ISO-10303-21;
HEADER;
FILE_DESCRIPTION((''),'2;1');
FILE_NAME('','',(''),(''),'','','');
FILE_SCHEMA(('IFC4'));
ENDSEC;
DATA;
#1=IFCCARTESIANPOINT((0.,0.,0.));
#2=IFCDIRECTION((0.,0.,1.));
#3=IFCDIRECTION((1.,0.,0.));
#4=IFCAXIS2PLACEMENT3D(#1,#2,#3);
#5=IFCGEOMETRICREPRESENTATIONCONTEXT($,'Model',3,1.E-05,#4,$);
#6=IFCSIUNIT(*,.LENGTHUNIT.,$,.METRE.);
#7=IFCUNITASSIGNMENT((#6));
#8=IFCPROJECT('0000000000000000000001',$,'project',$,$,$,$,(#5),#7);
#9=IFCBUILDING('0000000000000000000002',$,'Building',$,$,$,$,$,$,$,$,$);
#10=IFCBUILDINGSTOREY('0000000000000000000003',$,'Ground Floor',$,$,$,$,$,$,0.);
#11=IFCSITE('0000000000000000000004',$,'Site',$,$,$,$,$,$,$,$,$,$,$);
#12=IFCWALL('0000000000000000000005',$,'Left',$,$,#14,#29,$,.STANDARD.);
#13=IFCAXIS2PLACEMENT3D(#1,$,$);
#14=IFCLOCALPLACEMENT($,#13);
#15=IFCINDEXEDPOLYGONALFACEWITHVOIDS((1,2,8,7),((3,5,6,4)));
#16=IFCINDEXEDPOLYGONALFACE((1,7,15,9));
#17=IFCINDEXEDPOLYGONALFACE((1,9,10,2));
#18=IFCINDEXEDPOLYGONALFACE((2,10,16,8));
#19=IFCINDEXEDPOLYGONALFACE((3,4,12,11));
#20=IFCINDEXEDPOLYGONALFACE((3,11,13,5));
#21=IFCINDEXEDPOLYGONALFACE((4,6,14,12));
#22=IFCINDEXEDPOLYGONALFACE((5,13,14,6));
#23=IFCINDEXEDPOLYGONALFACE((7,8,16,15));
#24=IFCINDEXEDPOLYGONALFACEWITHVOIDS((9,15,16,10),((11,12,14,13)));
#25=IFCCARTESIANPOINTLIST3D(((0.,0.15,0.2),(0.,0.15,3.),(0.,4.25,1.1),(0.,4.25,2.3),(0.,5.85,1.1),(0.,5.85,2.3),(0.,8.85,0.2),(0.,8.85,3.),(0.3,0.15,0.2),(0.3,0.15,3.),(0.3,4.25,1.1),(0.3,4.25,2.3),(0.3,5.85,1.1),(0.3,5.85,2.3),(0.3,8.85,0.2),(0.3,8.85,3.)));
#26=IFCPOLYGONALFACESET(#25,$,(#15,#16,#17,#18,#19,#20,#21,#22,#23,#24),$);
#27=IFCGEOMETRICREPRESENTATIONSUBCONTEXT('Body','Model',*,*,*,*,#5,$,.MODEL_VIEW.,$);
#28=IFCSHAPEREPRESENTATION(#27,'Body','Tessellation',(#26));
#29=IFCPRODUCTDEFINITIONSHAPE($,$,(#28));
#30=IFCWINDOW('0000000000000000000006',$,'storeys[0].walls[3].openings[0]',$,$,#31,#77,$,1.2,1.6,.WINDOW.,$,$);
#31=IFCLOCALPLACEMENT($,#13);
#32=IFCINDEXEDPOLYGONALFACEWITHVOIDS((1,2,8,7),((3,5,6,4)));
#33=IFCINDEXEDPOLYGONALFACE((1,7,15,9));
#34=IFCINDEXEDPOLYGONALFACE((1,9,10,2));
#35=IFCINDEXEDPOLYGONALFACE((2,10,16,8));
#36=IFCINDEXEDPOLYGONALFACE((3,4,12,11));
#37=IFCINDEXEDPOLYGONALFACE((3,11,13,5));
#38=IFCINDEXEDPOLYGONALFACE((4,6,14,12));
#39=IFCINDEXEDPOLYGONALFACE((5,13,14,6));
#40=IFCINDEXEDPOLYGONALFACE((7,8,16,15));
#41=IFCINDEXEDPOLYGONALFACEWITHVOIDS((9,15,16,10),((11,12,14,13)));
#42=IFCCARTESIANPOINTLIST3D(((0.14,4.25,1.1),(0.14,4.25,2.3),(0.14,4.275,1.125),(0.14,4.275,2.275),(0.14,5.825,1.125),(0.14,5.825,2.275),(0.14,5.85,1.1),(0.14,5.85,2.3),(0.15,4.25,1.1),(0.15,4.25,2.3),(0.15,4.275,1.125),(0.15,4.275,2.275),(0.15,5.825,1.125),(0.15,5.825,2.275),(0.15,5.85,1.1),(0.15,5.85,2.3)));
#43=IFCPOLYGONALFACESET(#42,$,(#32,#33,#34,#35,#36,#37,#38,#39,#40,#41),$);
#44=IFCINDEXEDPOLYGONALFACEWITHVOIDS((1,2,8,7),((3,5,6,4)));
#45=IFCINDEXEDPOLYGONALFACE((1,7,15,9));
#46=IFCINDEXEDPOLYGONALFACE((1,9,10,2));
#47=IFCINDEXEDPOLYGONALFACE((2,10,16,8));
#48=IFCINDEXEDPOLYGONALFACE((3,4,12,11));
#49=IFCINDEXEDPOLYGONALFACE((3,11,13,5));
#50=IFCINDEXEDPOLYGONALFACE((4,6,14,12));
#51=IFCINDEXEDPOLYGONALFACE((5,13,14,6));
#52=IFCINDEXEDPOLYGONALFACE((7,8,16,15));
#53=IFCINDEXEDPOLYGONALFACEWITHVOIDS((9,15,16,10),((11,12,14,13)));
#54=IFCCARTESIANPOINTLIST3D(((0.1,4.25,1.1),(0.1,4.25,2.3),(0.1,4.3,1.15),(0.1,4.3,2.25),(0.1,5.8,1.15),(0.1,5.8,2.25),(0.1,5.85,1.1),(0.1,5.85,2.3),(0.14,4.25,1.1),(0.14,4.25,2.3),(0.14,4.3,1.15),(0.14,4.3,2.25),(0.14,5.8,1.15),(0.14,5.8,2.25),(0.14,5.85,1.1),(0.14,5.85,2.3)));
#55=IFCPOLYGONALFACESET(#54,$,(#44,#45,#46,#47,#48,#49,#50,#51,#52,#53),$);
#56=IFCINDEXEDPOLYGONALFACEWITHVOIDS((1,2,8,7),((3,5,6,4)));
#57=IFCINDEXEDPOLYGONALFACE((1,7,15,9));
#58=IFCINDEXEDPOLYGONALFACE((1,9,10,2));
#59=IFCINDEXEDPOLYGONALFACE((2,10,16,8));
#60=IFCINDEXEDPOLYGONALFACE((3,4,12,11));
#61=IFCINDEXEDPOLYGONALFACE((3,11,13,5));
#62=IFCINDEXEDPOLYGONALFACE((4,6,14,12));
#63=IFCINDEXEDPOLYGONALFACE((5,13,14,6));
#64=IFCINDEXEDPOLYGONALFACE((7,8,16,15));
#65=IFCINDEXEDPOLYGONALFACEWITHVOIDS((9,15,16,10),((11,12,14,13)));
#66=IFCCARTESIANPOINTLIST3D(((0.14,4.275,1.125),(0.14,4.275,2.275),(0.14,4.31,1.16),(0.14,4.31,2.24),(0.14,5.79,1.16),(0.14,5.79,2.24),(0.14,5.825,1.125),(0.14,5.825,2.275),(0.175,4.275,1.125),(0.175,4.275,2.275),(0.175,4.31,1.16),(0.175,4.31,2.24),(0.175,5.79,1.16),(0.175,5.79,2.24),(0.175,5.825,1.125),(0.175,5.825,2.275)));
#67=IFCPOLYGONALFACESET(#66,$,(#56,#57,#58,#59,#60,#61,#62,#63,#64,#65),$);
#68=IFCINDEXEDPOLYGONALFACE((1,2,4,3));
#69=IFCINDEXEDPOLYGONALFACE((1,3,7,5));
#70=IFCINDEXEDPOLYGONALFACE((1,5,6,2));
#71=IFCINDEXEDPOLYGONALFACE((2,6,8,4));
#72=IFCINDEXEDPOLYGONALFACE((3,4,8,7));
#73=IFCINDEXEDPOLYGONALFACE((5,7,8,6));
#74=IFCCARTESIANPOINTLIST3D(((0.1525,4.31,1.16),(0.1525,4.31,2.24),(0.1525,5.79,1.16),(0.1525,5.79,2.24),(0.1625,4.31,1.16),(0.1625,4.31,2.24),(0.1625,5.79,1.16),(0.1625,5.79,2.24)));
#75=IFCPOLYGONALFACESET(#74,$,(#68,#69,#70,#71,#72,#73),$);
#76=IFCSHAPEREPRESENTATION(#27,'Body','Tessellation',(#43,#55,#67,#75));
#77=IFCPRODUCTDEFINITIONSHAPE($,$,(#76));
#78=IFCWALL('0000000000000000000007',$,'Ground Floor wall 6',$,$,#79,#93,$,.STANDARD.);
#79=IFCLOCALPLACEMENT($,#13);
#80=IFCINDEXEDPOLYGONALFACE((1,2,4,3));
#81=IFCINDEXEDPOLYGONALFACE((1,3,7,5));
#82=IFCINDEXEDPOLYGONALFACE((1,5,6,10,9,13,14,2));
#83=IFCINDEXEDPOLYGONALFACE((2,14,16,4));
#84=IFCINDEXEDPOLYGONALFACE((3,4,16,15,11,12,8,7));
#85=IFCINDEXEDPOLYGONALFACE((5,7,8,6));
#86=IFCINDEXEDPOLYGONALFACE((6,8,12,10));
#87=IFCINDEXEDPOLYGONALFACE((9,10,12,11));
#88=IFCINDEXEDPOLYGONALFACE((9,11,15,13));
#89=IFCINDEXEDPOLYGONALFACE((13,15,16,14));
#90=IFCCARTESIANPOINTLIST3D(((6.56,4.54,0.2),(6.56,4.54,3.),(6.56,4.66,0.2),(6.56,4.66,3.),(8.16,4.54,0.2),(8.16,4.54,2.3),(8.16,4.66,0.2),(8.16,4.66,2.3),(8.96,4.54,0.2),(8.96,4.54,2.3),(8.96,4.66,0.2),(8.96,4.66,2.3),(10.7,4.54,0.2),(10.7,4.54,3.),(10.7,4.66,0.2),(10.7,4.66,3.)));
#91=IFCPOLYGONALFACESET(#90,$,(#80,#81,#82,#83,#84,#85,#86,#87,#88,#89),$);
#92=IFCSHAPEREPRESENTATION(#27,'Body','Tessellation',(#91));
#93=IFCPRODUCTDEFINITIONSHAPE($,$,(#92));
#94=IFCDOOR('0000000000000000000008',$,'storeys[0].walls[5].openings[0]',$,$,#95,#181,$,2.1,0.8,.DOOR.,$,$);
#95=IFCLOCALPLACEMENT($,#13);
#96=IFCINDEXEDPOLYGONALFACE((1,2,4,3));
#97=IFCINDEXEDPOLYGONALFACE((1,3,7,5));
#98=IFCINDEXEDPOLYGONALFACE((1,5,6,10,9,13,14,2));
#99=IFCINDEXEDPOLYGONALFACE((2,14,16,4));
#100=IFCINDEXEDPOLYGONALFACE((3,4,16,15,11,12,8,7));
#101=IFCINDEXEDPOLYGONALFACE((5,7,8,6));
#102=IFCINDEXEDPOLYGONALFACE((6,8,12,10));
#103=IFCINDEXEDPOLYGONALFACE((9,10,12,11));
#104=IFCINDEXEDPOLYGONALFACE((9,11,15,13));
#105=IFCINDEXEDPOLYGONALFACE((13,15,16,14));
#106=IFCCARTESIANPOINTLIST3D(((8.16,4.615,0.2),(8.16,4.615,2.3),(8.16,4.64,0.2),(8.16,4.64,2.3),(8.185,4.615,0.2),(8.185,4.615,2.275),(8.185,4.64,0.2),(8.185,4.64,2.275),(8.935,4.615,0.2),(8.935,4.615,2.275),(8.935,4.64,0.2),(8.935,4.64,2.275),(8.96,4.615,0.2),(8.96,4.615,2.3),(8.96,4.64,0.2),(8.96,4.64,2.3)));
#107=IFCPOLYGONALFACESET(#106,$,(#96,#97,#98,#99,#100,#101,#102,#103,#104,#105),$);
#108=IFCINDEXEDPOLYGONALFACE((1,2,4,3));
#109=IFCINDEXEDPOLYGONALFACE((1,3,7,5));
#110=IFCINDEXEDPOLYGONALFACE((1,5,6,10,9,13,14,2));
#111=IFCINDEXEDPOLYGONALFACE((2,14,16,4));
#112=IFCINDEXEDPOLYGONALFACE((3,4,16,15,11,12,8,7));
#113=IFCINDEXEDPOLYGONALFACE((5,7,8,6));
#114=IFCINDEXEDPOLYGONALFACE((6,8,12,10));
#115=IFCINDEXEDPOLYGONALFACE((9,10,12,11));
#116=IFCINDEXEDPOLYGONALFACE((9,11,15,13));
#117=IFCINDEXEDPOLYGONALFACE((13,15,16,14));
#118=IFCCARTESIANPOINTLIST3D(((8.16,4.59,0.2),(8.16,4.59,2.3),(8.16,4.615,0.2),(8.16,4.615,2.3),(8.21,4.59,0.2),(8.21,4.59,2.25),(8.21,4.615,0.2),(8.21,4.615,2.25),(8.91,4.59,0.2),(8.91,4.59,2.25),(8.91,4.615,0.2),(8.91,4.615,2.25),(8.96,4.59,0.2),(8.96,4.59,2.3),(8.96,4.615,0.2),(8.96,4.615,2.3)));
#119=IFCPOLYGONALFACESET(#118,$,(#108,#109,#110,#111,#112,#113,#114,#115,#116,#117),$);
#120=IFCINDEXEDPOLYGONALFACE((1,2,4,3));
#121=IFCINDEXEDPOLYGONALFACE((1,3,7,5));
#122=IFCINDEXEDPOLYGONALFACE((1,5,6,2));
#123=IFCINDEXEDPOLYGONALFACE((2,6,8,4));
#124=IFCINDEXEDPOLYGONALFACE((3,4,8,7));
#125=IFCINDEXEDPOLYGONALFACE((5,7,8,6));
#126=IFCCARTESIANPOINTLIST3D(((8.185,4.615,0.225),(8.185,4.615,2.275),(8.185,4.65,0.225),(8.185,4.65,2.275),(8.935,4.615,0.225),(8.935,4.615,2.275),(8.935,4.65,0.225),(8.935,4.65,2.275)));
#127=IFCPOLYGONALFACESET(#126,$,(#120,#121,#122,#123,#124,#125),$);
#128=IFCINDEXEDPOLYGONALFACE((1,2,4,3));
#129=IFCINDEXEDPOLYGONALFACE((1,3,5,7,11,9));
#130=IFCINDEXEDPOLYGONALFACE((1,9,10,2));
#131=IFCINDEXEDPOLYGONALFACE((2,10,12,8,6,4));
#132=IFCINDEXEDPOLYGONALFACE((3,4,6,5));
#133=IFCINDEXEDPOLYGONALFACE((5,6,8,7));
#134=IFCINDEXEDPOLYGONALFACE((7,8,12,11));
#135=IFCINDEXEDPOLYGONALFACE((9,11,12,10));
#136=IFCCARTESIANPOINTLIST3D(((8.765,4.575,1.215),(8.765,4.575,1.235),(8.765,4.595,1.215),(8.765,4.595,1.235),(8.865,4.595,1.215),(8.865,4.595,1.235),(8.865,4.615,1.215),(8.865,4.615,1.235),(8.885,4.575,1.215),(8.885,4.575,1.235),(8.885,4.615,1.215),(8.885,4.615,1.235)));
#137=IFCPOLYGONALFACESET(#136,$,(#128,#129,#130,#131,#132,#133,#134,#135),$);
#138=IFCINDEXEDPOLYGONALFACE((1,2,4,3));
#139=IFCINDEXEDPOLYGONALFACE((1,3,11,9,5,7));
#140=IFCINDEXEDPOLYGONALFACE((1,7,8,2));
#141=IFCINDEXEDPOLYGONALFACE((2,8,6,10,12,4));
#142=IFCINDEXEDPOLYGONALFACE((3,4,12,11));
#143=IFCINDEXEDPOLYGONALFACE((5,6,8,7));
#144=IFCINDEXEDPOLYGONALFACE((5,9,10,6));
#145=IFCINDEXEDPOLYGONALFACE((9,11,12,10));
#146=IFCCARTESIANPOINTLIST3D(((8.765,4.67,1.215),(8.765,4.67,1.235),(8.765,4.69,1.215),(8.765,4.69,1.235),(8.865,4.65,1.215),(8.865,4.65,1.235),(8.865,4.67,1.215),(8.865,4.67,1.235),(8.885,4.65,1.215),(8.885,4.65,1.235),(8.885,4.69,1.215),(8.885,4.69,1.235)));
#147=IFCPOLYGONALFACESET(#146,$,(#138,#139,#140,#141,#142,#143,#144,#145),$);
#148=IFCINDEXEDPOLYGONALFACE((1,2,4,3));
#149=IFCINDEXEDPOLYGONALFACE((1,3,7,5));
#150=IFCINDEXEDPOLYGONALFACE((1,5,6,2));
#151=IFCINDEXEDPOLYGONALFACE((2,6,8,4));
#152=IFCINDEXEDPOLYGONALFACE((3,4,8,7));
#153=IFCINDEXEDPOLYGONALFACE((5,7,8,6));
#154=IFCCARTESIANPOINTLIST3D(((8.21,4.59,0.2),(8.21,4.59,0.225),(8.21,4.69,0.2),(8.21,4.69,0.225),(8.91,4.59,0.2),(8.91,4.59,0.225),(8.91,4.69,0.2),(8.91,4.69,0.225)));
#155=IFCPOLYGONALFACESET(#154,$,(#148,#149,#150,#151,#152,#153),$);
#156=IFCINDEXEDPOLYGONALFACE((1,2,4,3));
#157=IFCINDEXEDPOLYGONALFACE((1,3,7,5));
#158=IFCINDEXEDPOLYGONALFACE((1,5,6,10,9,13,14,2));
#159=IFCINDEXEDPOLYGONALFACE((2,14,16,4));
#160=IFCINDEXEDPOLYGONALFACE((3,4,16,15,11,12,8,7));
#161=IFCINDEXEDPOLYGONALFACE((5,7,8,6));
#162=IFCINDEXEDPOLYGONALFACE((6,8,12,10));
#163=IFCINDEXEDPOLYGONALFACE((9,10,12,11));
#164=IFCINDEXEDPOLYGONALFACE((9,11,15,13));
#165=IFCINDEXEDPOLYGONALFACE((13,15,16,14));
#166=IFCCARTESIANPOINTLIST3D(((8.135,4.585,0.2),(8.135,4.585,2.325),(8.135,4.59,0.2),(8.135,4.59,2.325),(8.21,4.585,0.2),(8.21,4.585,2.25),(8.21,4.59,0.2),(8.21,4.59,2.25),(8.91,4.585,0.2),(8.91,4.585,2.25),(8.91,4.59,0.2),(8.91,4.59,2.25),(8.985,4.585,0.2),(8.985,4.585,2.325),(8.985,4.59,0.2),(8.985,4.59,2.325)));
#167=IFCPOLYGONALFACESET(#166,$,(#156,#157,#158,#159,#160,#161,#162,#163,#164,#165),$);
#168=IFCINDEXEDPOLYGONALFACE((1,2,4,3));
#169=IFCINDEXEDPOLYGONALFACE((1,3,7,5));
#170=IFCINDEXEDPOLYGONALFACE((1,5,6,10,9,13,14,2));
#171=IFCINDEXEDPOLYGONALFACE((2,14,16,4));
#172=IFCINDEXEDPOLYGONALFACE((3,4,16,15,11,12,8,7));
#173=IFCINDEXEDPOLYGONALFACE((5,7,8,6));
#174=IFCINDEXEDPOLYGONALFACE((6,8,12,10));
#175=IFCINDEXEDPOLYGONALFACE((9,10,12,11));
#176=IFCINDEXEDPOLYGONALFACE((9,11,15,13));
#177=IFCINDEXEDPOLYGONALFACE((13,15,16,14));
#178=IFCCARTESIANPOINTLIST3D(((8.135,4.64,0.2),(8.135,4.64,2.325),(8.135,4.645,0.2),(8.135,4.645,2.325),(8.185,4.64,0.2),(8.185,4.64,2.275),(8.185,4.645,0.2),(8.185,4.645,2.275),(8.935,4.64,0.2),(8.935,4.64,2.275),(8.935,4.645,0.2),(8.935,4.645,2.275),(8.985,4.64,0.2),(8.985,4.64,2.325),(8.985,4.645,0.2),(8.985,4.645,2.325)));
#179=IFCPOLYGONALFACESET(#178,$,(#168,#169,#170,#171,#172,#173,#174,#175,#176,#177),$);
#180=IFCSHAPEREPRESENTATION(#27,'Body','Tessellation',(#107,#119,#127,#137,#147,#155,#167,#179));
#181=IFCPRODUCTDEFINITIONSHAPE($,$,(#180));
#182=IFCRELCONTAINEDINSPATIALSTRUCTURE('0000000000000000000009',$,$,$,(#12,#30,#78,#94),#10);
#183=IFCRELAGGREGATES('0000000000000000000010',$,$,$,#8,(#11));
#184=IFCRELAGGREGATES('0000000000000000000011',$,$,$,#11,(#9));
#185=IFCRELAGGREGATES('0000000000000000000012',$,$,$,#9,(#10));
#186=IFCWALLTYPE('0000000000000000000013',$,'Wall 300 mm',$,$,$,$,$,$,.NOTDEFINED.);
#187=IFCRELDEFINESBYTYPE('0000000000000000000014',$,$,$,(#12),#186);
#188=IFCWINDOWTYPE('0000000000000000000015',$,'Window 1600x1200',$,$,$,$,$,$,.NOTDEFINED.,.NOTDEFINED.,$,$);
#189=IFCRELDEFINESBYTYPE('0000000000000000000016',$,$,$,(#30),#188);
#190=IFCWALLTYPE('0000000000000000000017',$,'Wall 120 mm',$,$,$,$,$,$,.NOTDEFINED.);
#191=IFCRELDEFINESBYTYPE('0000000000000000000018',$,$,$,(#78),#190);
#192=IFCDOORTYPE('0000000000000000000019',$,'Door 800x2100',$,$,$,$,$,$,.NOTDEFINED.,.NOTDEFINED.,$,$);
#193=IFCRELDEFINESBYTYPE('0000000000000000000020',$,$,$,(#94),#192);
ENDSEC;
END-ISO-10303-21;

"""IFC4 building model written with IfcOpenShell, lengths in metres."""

from ifc_helpers import new_model, si_unit, frame, origin_with_axes, place, context, subcontext, project, spatial, line, indexed_curve, outline, extrude, type_object, element, fill, save


model = new_model("IFC4")

# Units and contexts
model_context = context("Model", 3, precision=1e-05, world=origin_with_axes())
body_context = subcontext(model_context, "Body", "Model", "MODEL_VIEW")
ifc_project = project(units=[si_unit("LENGTHUNIT", "METRE")], contexts=[model_context])

# Site, building, storey
site = spatial("IfcSite", under=ifc_project, Name="Site")
building = spatial("IfcBuilding", under=site, Name="Building")
storey = spatial("IfcBuildingStorey", under=building, Name="Ground Floor", Elevation=0.0)

# Shared definitions
wall_type_1 = type_object("IfcWallType", Name="Wall 300 mm", PredefinedType="NOTDEFINED")
window_type_1 = type_object("IfcWindowType", Name="Window 1600x1200", PartitioningType="NOTDEFINED", PredefinedType="NOTDEFINED")

# Wall, opening, window
wall_1_placement = place(None, frame((0.15, 8.85, 0.2), z_axis=(0.0, 0.0, 1.0), x_axis=(0.0, -1.0, 0.0)))
wall_1 = element("IfcWall", 1, at=wall_1_placement, inside=storey, type_object=wall_type_1, Name="Left", PredefinedType="STANDARD", context=body_context, shape_type="SweptSolid", body=[
    extrude(outline(indexed_curve([(0.0, 0.0), (0.0, 0.3), (8.7, 0.3), (8.7, 0.0), (0.0, 0.0)], self_intersect=False)), frame((0.0, -0.15, 0.0), z_axis=(0.0, 0.0, 1.0), x_axis=(1.0, 0.0, 0.0)), (0.0, 0.0, 1.0), 2.8),
])
opening_1_placement = place(wall_1_placement, frame((3.0, -0.16, 0.9), z_axis=(0.0, 0.0, 1.0), x_axis=(1.0, 0.0, 0.0)))
opening_1 = element("IfcOpeningElement", 2, at=opening_1_placement, cuts=wall_1, context=body_context, shape_type="SweptSolid", body=[
    extrude(outline(indexed_curve([(0.0, 0.0), (0.0, 0.32), (1.6, 0.32), (1.6, 0.0), (0.0, 0.0)], self_intersect=False)), origin_with_axes(), (0.0, 0.0, 1.0), 1.2),
])
window_1_placement = place(None, frame((0.05, 5.85, 1.1), z_axis=(0.0, 0.0, 1.0), x_axis=(0.0, -1.0, 0.0)))
window_1 = element("IfcWindow", 3, at=window_1_placement, inside=storey, type_object=window_type_1, Name="storeys[0].walls[3].openings[0]", OverallHeight=1.2, OverallWidth=1.6, PredefinedType="WINDOW", context=body_context, shape_type="SweptSolid", body=[
    extrude(outline(indexed_curve([(0.0, 0.0), (1.6, 0.0), (1.6, 1.2), (0.0, 1.2)], segments=[line(1, 2, 3, 4, 1)]), holes=[indexed_curve([(0.025, 0.025), (1.575, 0.025), (1.575, 1.175), (0.025, 1.175)], segments=[line(1, 2, 3, 4, 1)])]), frame((0.0, 0.09, 0.0), z_axis=(0.0, -1.0, 0.0), x_axis=(1.0, 0.0, 0.0)), (0.0, 0.0, -1.0), 0.01),
    extrude(outline(indexed_curve([(0.0, 0.0), (1.6, 0.0), (1.6, 1.2), (0.0, 1.2)], segments=[line(1, 2, 3, 4, 1)]), holes=[indexed_curve([(0.05, 0.05), (1.55, 0.05), (1.55, 1.15), (0.05, 1.15)], segments=[line(1, 2, 3, 4, 1)])]), frame((0.0, 0.05, 0.0), z_axis=(0.0, -1.0, 0.0), x_axis=(1.0, 0.0, 0.0)), (0.0, 0.0, -1.0), 0.04),
    extrude(outline(indexed_curve([(0.0, 0.0), (1.55, 0.0), (1.55, 1.15), (0.0, 1.15)], segments=[line(1, 2, 3, 4, 1)]), holes=[indexed_curve([(0.035, 0.035), (1.515, 0.035), (1.515, 1.115), (0.035, 1.115)], segments=[line(1, 2, 3, 4, 1)])]), frame((0.025, 0.09, 0.025), z_axis=(0.0, -1.0, 0.0), x_axis=(1.0, 0.0, 0.0)), (0.0, 0.0, -1.0), 0.035),
    extrude(outline(indexed_curve([(0.035, 0.035), (1.515, 0.035), (1.515, 1.115), (0.035, 1.115)], segments=[line(1, 2, 3, 4, 1)])), frame((0.025, 0.1025, 0.025), z_axis=(0.0, -1.0, 0.0), x_axis=(1.0, 0.0, 0.0)), (0.0, 0.0, -1.0), 0.01),
])
fill(opening_1, window_1)

# Shared definitions
wall_type_2 = type_object("IfcWallType", Name="Wall 120 mm", PredefinedType="NOTDEFINED")

# Wall, opening, door
wall_2_placement = place(None, frame((6.56, 4.6, 0.2), z_axis=(0.0, 0.0, 1.0), x_axis=(1.0, 0.0, 0.0)))
wall_2 = element("IfcWall", 4, at=wall_2_placement, inside=storey, type_object=wall_type_2, Name="Ground Floor wall 6", PredefinedType="STANDARD", context=body_context, shape_type="SweptSolid", body=[
    extrude(outline(indexed_curve([(0.0, 0.0), (0.0, 0.12), (4.14, 0.12), (4.14, 0.0), (0.0, 0.0)], self_intersect=False)), frame((0.0, -0.06, 0.0), z_axis=(0.0, 0.0, 1.0), x_axis=(1.0, 0.0, 0.0)), (0.0, 0.0, 1.0), 2.8),
])
opening_2_placement = place(wall_2_placement, frame((1.6, -0.07, 0.0), z_axis=(0.0, 0.0, 1.0), x_axis=(1.0, 0.0, 0.0)))
opening_2 = element("IfcOpeningElement", 5, at=opening_2_placement, cuts=wall_2, context=body_context, shape_type="SweptSolid", body=[
    extrude(outline(indexed_curve([(0.0, 0.0), (0.0, 0.14), (0.8, 0.14), (0.8, 0.0), (0.0, 0.0)], self_intersect=False)), origin_with_axes(), (0.0, 0.0, 1.0), 2.1),
])
door_type_1 = type_object("IfcDoorType", Name="Door 800x2100", OperationType="NOTDEFINED", PredefinedType="NOTDEFINED")
door_1_placement = place(None, frame((8.16, 4.59, 0.2), z_axis=(0.0, 0.0, 1.0), x_axis=(1.0, 0.0, 0.0)))
door_1 = element("IfcDoor", 6, at=door_1_placement, inside=storey, type_object=door_type_1, Name="storeys[0].walls[5].openings[0]", OverallHeight=2.1, OverallWidth=0.8, PredefinedType="DOOR", context=body_context, shape_type="SweptSolid", body=[
    extrude(outline(indexed_curve([(0.0, 0.0), (0.0, 2.1), (0.8, 2.1), (0.8, 0.0), (0.775, 0.0), (0.775, 2.075), (0.025, 2.075), (0.025, 0.0)], segments=[line(1, 2, 3, 4, 5, 6, 7, 8, 1)])), frame((0.0, 0.025, 0.0), z_axis=(0.0, -1.0, 0.0), x_axis=(1.0, 0.0, 0.0)), (0.0, 0.0, -1.0), 0.025),
    extrude(outline(indexed_curve([(0.0, 0.0), (0.0, 2.1), (0.8, 2.1), (0.8, 0.0), (0.75, 0.0), (0.75, 2.05), (0.05, 2.05), (0.05, 0.0)], segments=[line(1, 2, 3, 4, 5, 6, 7, 8, 1)])), frame((0.0, 0.0, 0.0), z_axis=(0.0, -1.0, 0.0), x_axis=(1.0, 0.0, 0.0)), (0.0, 0.0, -1.0), 0.025),
    extrude(outline(indexed_curve([(0.0, 0.0), (0.75, 0.0), (0.75, 0.035), (0.0, 0.035)], segments=[line(1, 2, 3, 4, 1)])), frame((0.025, 0.025, 0.025), z_axis=(0.0, 0.0, 1.0), x_axis=(1.0, 0.0, 0.0)), (0.0, 0.0, 1.0), 2.05),
    extrude(outline(indexed_curve([(0.0, 0.0), (0.0, -0.04), (-0.12, -0.04), (-0.12, -0.02), (-0.02, -0.02), (-0.02, 0.0)], segments=[line(1, 2, 3, 4, 5, 6, 1)])), frame((0.725, 0.025, 1.015), z_axis=(0.0, 0.0, 1.0), x_axis=(1.0, 0.0, 0.0)), (0.0, 0.0, 1.0), 0.02),
    extrude(outline(indexed_curve([(0.0, 0.0), (0.0, 0.04), (-0.12, 0.04), (-0.12, 0.02), (-0.02, 0.02), (-0.02, 0.0)], segments=[line(1, 2, 3, 4, 5, 6, 1)])), frame((0.725, 0.06, 1.015), z_axis=(0.0, 0.0, 1.0), x_axis=(1.0, 0.0, 0.0)), (0.0, 0.0, 1.0), 0.02),
    extrude(outline(indexed_curve([(0.0, 0.0), (0.7, 0.0), (0.7, 0.1), (0.0, 0.1)], segments=[line(1, 2, 3, 4, 1)])), frame((0.05, 0.0, 0.0), z_axis=(0.0, 0.0, 1.0), x_axis=(1.0, 0.0, 0.0)), (0.0, 0.0, 1.0), 0.025),
    extrude(outline(indexed_curve([(0.0, 0.0), (0.0, 2.125), (0.85, 2.125), (0.85, 0.0), (0.775, 0.0), (0.775, 2.05), (0.075, 2.05), (0.075, 0.0)], segments=[line(1, 2, 3, 4, 5, 6, 7, 8, 1)])), frame((-0.025, -0.005, 0.0), z_axis=(0.0, -1.0, 0.0), x_axis=(1.0, 0.0, 0.0)), (0.0, 0.0, -1.0), 0.005),
    extrude(outline(indexed_curve([(0.0, 0.0), (0.0, 2.125), (0.85, 2.125), (0.85, 0.0), (0.8, 0.0), (0.8, 2.075), (0.05, 2.075), (0.05, 0.0)], segments=[line(1, 2, 3, 4, 5, 6, 7, 8, 1)])), frame((-0.025, 0.05, 0.0), z_axis=(0.0, -1.0, 0.0), x_axis=(1.0, 0.0, 0.0)), (0.0, 0.0, -1.0), 0.005),
])
fill(opening_2, door_1)

save(model, "model.ifc")
